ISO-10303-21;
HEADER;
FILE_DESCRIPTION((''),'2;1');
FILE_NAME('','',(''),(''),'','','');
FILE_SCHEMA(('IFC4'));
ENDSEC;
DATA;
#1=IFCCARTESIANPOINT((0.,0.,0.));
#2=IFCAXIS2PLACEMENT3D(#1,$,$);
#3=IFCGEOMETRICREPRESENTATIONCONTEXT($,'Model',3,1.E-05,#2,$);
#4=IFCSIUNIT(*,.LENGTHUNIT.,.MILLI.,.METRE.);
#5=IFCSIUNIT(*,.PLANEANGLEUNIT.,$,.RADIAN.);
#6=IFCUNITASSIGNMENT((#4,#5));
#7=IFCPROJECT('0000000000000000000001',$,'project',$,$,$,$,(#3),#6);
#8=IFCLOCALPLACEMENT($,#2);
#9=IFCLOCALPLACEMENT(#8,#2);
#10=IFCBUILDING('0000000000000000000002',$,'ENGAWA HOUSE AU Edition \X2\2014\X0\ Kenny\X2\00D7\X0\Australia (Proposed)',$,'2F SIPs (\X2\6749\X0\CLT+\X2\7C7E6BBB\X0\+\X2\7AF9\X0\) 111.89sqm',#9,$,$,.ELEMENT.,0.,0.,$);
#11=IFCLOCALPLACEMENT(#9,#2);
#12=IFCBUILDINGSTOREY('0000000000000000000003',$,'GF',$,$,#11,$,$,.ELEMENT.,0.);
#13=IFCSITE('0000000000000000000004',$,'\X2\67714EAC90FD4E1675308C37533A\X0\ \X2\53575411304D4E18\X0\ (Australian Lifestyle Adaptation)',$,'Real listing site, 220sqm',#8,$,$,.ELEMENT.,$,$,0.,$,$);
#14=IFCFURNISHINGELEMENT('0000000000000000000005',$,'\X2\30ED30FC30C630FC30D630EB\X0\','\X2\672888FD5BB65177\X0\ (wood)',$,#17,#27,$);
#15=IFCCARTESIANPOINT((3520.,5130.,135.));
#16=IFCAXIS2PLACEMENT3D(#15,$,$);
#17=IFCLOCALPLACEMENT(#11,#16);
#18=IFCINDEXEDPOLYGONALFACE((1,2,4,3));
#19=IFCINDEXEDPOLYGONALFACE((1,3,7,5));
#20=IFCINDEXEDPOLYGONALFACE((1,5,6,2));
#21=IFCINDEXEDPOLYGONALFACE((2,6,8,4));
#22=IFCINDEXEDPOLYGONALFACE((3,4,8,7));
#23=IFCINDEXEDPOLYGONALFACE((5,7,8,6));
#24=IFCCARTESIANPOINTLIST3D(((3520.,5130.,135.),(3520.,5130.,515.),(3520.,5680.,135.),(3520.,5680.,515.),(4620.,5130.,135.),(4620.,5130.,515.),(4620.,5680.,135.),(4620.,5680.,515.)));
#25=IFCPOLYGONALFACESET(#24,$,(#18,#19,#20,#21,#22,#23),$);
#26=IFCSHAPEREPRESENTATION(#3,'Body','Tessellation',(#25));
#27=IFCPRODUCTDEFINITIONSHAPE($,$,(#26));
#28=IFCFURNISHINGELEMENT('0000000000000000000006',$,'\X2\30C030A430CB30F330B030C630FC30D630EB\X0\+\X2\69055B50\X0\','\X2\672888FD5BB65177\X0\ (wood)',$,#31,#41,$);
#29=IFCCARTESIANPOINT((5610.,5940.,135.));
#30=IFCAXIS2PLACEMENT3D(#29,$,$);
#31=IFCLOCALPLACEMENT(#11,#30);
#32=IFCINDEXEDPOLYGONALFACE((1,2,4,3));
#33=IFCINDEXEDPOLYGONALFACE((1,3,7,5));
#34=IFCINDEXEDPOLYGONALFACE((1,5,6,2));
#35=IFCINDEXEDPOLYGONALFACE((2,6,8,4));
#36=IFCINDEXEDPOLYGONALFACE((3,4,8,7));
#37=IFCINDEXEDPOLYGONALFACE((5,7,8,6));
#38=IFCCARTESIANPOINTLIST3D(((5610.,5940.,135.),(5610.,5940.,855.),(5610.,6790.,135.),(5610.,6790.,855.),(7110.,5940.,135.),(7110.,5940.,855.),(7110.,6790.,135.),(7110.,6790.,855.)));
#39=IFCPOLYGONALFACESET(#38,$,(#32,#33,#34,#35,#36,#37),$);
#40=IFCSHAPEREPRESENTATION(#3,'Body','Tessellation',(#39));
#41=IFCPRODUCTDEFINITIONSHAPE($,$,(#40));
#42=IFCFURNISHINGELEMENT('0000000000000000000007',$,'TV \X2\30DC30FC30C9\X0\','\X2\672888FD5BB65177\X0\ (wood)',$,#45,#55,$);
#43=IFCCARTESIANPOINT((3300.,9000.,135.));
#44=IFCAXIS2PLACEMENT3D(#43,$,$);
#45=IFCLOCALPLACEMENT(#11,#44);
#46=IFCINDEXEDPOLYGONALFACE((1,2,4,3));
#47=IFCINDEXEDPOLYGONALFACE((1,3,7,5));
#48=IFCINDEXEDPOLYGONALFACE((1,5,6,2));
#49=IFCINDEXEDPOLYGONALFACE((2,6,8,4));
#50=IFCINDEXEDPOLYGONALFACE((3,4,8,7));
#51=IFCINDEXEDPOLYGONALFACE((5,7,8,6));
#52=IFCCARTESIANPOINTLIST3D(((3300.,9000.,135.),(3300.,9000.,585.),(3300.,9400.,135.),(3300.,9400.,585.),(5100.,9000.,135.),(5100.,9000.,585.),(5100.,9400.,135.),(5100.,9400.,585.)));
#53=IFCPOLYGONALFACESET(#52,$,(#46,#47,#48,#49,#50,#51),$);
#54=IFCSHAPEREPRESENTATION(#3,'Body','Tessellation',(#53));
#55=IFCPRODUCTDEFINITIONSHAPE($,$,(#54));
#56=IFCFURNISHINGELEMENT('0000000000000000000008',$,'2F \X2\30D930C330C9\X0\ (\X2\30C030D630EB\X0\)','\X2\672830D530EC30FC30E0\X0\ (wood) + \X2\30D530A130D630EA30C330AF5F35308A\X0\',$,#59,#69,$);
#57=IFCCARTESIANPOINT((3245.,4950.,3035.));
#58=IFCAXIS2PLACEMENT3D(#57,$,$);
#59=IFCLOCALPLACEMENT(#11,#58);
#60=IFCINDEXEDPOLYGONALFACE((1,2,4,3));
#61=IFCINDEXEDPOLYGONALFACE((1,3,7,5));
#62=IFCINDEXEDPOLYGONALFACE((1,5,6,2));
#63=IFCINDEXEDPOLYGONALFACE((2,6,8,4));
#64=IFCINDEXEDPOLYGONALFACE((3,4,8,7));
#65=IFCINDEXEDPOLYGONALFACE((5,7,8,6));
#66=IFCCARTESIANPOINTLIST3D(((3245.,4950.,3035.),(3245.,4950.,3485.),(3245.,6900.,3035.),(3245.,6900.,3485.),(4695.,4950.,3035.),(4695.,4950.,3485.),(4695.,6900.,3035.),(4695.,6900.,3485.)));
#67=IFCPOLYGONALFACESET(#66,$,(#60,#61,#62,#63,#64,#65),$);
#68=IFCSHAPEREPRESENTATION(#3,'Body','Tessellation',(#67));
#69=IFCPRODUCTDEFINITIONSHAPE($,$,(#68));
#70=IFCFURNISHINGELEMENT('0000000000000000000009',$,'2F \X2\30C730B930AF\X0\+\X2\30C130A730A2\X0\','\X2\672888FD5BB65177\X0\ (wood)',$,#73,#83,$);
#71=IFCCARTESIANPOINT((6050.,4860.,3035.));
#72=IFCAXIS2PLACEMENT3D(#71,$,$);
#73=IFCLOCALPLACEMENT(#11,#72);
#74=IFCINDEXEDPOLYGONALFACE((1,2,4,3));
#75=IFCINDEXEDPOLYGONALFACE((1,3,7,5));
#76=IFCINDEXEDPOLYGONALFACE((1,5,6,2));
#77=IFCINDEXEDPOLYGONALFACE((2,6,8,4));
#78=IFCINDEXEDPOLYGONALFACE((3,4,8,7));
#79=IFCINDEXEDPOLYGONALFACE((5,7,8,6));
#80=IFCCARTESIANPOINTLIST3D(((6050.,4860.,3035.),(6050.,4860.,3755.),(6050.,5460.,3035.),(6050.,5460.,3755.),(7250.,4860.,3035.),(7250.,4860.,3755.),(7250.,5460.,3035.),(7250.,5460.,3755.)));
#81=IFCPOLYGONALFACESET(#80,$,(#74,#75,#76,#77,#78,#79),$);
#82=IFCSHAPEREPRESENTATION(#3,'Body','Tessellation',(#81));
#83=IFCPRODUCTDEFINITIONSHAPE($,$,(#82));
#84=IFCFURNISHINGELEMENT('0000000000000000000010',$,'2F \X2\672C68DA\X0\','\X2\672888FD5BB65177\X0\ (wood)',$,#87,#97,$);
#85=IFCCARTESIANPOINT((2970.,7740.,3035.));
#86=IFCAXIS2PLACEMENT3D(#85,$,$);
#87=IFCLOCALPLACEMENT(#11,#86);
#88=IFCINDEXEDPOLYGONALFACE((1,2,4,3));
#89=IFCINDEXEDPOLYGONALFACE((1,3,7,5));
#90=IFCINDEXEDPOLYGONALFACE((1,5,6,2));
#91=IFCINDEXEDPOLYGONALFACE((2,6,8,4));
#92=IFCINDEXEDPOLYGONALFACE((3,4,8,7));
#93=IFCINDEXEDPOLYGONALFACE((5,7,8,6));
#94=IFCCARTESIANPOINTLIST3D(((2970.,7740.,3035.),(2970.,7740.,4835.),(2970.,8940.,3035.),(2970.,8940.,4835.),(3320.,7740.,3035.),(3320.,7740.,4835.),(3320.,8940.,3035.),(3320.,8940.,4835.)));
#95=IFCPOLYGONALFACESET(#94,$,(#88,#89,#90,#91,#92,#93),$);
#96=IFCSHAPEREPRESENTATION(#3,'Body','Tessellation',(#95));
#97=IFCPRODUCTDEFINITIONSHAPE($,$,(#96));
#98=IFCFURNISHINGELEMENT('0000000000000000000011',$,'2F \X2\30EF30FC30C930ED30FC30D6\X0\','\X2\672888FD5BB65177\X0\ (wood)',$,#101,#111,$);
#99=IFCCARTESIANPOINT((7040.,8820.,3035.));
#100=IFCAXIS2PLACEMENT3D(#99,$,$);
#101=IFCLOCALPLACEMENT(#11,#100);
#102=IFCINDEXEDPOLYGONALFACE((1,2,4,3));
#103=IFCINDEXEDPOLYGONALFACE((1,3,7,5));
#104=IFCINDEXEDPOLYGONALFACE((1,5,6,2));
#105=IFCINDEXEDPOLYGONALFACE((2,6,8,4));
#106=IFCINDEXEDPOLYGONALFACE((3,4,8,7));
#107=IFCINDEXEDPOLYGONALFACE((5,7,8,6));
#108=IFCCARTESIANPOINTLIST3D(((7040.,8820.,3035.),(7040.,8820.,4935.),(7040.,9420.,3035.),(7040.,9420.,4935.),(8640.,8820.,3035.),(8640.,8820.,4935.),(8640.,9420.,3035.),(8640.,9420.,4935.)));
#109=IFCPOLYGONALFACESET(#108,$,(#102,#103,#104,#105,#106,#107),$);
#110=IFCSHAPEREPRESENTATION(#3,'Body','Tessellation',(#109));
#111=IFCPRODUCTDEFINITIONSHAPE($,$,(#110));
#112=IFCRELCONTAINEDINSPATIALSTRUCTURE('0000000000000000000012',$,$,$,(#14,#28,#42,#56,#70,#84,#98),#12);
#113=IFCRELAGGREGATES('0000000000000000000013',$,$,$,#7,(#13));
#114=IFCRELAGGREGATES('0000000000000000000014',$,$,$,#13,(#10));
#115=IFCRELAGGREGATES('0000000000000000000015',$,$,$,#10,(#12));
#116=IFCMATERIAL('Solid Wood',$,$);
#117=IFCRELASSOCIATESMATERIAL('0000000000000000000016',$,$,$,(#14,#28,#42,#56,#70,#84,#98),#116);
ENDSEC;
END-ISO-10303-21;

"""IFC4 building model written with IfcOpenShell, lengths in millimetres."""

from ifc_helpers import new_model, si_unit, frame, frame_2d, origin, place, context, project, spatial, rectangle, extrude, material, element, save


model = new_model("IFC4")

# Units and contexts
model_context = context("Model", 3, precision=1e-05, world=origin())
ifc_project = project(units=[si_unit("LENGTHUNIT", "METRE", prefix="MILLI"), si_unit("PLANEANGLEUNIT", "RADIAN")], contexts=[model_context])

# Site, building, storey
site_placement = place(None, origin())
site = spatial("IfcSite", under=ifc_project, at=site_placement, Name="東京都世田谷区 南向き丘 (Australian Lifestyle Adaptation)", ObjectType="Real listing site, 220sqm", CompositionType="ELEMENT", RefElevation=0.0)
building_placement = place(site_placement, origin())
building = spatial("IfcBuilding", under=site, at=building_placement, Name="ENGAWA HOUSE AU Edition — Kenny×Australia (Proposed)", ObjectType="2F SIPs (杉CLT+籾殻+竹) 111.89sqm", CompositionType="ELEMENT", ElevationOfRefHeight=0.0, ElevationOfTerrain=0.0)
storey_placement = place(building_placement, origin())
storey = spatial("IfcBuildingStorey", under=building, at=storey_placement, Name="GF", CompositionType="ELEMENT", Elevation=0.0)

# Shared definitions
ifc_material_1 = material(Name="Solid Wood")

# Furnishing elements
furnishing_1_placement = place(storey_placement, frame((3520.0, 5130.0, 135.0)))
element("IfcFurnishingElement", 1, at=furnishing_1_placement, inside=storey, material=ifc_material_1, Name="ローテーブル", Description="木製家具 (wood)", context=model_context, shape_type="SweptSolid", body=[
    extrude(rectangle(XDim=1100.0, YDim=550.0, at=frame_2d((550.0, 275.0))), frame((3520.0, 5130.0, 135.0)), (0.0, 0.0, 1.0), 380.0),
])
furnishing_2_placement = place(storey_placement, frame((5610.0, 5940.0, 135.0)))
element("IfcFurnishingElement", 2, at=furnishing_2_placement, inside=storey, material=ifc_material_1, Name="ダイニングテーブル+椅子", Description="木製家具 (wood)", context=model_context, shape_type="SweptSolid", body=[
    extrude(rectangle(XDim=1500.0, YDim=850.0, at=frame_2d((750.0, 425.0))), frame((5610.0, 5940.0, 135.0)), (0.0, 0.0, 1.0), 720.0),
])
furnishing_3_placement = place(storey_placement, frame((3300.0, 9000.0, 135.0)))
element("IfcFurnishingElement", 3, at=furnishing_3_placement, inside=storey, material=ifc_material_1, Name="TV ボード", Description="木製家具 (wood)", context=model_context, shape_type="SweptSolid", body=[
    extrude(rectangle(XDim=1800.0, YDim=400.0, at=frame_2d((900.0, 200.0))), frame((3300.0, 9000.0, 135.0)), (0.0, 0.0, 1.0), 450.0),
])
furnishing_4_placement = place(storey_placement, frame((3245.0, 4950.0, 3035.0)))
element("IfcFurnishingElement", 4, at=furnishing_4_placement, inside=storey, material=ifc_material_1, Name="2F ベッド (ダブル)", Description="木フレーム (wood) + ファブリック張り", context=model_context, shape_type="SweptSolid", body=[
    extrude(rectangle(XDim=1450.0, YDim=1950.0, at=frame_2d((725.0, 975.0))), frame((3245.0, 4950.0, 3035.0)), (0.0, 0.0, 1.0), 450.0),
])
furnishing_5_placement = place(storey_placement, frame((6050.0, 4860.0, 3035.0)))
element("IfcFurnishingElement", 5, at=furnishing_5_placement, inside=storey, material=ifc_material_1, Name="2F デスク+チェア", Description="木製家具 (wood)", context=model_context, shape_type="SweptSolid", body=[
    extrude(rectangle(XDim=1200.0, YDim=600.0, at=frame_2d((600.0, 300.0))), frame((6050.0, 4860.0, 3035.0)), (0.0, 0.0, 1.0), 720.0),
])
furnishing_6_placement = place(storey_placement, frame((2970.0, 7740.0, 3035.0)))
element("IfcFurnishingElement", 6, at=furnishing_6_placement, inside=storey, material=ifc_material_1, Name="2F 本棚", Description="木製家具 (wood)", context=model_context, shape_type="SweptSolid", body=[
    extrude(rectangle(XDim=350.0, YDim=1200.0, at=frame_2d((175.0, 600.0))), frame((2970.0, 7740.0, 3035.0)), (0.0, 0.0, 1.0), 1800.0),
])
furnishing_7_placement = place(storey_placement, frame((7040.0, 8820.0, 3035.0)))
element("IfcFurnishingElement", 7, at=furnishing_7_placement, inside=storey, material=ifc_material_1, Name="2F ワードローブ", Description="木製家具 (wood)", context=model_context, shape_type="SweptSolid", body=[
    extrude(rectangle(XDim=1600.0, YDim=600.0, at=frame_2d((800.0, 300.0))), frame((7040.0, 8820.0, 3035.0)), (0.0, 0.0, 1.0), 1900.0),
])

save(model, "model.ifc")
